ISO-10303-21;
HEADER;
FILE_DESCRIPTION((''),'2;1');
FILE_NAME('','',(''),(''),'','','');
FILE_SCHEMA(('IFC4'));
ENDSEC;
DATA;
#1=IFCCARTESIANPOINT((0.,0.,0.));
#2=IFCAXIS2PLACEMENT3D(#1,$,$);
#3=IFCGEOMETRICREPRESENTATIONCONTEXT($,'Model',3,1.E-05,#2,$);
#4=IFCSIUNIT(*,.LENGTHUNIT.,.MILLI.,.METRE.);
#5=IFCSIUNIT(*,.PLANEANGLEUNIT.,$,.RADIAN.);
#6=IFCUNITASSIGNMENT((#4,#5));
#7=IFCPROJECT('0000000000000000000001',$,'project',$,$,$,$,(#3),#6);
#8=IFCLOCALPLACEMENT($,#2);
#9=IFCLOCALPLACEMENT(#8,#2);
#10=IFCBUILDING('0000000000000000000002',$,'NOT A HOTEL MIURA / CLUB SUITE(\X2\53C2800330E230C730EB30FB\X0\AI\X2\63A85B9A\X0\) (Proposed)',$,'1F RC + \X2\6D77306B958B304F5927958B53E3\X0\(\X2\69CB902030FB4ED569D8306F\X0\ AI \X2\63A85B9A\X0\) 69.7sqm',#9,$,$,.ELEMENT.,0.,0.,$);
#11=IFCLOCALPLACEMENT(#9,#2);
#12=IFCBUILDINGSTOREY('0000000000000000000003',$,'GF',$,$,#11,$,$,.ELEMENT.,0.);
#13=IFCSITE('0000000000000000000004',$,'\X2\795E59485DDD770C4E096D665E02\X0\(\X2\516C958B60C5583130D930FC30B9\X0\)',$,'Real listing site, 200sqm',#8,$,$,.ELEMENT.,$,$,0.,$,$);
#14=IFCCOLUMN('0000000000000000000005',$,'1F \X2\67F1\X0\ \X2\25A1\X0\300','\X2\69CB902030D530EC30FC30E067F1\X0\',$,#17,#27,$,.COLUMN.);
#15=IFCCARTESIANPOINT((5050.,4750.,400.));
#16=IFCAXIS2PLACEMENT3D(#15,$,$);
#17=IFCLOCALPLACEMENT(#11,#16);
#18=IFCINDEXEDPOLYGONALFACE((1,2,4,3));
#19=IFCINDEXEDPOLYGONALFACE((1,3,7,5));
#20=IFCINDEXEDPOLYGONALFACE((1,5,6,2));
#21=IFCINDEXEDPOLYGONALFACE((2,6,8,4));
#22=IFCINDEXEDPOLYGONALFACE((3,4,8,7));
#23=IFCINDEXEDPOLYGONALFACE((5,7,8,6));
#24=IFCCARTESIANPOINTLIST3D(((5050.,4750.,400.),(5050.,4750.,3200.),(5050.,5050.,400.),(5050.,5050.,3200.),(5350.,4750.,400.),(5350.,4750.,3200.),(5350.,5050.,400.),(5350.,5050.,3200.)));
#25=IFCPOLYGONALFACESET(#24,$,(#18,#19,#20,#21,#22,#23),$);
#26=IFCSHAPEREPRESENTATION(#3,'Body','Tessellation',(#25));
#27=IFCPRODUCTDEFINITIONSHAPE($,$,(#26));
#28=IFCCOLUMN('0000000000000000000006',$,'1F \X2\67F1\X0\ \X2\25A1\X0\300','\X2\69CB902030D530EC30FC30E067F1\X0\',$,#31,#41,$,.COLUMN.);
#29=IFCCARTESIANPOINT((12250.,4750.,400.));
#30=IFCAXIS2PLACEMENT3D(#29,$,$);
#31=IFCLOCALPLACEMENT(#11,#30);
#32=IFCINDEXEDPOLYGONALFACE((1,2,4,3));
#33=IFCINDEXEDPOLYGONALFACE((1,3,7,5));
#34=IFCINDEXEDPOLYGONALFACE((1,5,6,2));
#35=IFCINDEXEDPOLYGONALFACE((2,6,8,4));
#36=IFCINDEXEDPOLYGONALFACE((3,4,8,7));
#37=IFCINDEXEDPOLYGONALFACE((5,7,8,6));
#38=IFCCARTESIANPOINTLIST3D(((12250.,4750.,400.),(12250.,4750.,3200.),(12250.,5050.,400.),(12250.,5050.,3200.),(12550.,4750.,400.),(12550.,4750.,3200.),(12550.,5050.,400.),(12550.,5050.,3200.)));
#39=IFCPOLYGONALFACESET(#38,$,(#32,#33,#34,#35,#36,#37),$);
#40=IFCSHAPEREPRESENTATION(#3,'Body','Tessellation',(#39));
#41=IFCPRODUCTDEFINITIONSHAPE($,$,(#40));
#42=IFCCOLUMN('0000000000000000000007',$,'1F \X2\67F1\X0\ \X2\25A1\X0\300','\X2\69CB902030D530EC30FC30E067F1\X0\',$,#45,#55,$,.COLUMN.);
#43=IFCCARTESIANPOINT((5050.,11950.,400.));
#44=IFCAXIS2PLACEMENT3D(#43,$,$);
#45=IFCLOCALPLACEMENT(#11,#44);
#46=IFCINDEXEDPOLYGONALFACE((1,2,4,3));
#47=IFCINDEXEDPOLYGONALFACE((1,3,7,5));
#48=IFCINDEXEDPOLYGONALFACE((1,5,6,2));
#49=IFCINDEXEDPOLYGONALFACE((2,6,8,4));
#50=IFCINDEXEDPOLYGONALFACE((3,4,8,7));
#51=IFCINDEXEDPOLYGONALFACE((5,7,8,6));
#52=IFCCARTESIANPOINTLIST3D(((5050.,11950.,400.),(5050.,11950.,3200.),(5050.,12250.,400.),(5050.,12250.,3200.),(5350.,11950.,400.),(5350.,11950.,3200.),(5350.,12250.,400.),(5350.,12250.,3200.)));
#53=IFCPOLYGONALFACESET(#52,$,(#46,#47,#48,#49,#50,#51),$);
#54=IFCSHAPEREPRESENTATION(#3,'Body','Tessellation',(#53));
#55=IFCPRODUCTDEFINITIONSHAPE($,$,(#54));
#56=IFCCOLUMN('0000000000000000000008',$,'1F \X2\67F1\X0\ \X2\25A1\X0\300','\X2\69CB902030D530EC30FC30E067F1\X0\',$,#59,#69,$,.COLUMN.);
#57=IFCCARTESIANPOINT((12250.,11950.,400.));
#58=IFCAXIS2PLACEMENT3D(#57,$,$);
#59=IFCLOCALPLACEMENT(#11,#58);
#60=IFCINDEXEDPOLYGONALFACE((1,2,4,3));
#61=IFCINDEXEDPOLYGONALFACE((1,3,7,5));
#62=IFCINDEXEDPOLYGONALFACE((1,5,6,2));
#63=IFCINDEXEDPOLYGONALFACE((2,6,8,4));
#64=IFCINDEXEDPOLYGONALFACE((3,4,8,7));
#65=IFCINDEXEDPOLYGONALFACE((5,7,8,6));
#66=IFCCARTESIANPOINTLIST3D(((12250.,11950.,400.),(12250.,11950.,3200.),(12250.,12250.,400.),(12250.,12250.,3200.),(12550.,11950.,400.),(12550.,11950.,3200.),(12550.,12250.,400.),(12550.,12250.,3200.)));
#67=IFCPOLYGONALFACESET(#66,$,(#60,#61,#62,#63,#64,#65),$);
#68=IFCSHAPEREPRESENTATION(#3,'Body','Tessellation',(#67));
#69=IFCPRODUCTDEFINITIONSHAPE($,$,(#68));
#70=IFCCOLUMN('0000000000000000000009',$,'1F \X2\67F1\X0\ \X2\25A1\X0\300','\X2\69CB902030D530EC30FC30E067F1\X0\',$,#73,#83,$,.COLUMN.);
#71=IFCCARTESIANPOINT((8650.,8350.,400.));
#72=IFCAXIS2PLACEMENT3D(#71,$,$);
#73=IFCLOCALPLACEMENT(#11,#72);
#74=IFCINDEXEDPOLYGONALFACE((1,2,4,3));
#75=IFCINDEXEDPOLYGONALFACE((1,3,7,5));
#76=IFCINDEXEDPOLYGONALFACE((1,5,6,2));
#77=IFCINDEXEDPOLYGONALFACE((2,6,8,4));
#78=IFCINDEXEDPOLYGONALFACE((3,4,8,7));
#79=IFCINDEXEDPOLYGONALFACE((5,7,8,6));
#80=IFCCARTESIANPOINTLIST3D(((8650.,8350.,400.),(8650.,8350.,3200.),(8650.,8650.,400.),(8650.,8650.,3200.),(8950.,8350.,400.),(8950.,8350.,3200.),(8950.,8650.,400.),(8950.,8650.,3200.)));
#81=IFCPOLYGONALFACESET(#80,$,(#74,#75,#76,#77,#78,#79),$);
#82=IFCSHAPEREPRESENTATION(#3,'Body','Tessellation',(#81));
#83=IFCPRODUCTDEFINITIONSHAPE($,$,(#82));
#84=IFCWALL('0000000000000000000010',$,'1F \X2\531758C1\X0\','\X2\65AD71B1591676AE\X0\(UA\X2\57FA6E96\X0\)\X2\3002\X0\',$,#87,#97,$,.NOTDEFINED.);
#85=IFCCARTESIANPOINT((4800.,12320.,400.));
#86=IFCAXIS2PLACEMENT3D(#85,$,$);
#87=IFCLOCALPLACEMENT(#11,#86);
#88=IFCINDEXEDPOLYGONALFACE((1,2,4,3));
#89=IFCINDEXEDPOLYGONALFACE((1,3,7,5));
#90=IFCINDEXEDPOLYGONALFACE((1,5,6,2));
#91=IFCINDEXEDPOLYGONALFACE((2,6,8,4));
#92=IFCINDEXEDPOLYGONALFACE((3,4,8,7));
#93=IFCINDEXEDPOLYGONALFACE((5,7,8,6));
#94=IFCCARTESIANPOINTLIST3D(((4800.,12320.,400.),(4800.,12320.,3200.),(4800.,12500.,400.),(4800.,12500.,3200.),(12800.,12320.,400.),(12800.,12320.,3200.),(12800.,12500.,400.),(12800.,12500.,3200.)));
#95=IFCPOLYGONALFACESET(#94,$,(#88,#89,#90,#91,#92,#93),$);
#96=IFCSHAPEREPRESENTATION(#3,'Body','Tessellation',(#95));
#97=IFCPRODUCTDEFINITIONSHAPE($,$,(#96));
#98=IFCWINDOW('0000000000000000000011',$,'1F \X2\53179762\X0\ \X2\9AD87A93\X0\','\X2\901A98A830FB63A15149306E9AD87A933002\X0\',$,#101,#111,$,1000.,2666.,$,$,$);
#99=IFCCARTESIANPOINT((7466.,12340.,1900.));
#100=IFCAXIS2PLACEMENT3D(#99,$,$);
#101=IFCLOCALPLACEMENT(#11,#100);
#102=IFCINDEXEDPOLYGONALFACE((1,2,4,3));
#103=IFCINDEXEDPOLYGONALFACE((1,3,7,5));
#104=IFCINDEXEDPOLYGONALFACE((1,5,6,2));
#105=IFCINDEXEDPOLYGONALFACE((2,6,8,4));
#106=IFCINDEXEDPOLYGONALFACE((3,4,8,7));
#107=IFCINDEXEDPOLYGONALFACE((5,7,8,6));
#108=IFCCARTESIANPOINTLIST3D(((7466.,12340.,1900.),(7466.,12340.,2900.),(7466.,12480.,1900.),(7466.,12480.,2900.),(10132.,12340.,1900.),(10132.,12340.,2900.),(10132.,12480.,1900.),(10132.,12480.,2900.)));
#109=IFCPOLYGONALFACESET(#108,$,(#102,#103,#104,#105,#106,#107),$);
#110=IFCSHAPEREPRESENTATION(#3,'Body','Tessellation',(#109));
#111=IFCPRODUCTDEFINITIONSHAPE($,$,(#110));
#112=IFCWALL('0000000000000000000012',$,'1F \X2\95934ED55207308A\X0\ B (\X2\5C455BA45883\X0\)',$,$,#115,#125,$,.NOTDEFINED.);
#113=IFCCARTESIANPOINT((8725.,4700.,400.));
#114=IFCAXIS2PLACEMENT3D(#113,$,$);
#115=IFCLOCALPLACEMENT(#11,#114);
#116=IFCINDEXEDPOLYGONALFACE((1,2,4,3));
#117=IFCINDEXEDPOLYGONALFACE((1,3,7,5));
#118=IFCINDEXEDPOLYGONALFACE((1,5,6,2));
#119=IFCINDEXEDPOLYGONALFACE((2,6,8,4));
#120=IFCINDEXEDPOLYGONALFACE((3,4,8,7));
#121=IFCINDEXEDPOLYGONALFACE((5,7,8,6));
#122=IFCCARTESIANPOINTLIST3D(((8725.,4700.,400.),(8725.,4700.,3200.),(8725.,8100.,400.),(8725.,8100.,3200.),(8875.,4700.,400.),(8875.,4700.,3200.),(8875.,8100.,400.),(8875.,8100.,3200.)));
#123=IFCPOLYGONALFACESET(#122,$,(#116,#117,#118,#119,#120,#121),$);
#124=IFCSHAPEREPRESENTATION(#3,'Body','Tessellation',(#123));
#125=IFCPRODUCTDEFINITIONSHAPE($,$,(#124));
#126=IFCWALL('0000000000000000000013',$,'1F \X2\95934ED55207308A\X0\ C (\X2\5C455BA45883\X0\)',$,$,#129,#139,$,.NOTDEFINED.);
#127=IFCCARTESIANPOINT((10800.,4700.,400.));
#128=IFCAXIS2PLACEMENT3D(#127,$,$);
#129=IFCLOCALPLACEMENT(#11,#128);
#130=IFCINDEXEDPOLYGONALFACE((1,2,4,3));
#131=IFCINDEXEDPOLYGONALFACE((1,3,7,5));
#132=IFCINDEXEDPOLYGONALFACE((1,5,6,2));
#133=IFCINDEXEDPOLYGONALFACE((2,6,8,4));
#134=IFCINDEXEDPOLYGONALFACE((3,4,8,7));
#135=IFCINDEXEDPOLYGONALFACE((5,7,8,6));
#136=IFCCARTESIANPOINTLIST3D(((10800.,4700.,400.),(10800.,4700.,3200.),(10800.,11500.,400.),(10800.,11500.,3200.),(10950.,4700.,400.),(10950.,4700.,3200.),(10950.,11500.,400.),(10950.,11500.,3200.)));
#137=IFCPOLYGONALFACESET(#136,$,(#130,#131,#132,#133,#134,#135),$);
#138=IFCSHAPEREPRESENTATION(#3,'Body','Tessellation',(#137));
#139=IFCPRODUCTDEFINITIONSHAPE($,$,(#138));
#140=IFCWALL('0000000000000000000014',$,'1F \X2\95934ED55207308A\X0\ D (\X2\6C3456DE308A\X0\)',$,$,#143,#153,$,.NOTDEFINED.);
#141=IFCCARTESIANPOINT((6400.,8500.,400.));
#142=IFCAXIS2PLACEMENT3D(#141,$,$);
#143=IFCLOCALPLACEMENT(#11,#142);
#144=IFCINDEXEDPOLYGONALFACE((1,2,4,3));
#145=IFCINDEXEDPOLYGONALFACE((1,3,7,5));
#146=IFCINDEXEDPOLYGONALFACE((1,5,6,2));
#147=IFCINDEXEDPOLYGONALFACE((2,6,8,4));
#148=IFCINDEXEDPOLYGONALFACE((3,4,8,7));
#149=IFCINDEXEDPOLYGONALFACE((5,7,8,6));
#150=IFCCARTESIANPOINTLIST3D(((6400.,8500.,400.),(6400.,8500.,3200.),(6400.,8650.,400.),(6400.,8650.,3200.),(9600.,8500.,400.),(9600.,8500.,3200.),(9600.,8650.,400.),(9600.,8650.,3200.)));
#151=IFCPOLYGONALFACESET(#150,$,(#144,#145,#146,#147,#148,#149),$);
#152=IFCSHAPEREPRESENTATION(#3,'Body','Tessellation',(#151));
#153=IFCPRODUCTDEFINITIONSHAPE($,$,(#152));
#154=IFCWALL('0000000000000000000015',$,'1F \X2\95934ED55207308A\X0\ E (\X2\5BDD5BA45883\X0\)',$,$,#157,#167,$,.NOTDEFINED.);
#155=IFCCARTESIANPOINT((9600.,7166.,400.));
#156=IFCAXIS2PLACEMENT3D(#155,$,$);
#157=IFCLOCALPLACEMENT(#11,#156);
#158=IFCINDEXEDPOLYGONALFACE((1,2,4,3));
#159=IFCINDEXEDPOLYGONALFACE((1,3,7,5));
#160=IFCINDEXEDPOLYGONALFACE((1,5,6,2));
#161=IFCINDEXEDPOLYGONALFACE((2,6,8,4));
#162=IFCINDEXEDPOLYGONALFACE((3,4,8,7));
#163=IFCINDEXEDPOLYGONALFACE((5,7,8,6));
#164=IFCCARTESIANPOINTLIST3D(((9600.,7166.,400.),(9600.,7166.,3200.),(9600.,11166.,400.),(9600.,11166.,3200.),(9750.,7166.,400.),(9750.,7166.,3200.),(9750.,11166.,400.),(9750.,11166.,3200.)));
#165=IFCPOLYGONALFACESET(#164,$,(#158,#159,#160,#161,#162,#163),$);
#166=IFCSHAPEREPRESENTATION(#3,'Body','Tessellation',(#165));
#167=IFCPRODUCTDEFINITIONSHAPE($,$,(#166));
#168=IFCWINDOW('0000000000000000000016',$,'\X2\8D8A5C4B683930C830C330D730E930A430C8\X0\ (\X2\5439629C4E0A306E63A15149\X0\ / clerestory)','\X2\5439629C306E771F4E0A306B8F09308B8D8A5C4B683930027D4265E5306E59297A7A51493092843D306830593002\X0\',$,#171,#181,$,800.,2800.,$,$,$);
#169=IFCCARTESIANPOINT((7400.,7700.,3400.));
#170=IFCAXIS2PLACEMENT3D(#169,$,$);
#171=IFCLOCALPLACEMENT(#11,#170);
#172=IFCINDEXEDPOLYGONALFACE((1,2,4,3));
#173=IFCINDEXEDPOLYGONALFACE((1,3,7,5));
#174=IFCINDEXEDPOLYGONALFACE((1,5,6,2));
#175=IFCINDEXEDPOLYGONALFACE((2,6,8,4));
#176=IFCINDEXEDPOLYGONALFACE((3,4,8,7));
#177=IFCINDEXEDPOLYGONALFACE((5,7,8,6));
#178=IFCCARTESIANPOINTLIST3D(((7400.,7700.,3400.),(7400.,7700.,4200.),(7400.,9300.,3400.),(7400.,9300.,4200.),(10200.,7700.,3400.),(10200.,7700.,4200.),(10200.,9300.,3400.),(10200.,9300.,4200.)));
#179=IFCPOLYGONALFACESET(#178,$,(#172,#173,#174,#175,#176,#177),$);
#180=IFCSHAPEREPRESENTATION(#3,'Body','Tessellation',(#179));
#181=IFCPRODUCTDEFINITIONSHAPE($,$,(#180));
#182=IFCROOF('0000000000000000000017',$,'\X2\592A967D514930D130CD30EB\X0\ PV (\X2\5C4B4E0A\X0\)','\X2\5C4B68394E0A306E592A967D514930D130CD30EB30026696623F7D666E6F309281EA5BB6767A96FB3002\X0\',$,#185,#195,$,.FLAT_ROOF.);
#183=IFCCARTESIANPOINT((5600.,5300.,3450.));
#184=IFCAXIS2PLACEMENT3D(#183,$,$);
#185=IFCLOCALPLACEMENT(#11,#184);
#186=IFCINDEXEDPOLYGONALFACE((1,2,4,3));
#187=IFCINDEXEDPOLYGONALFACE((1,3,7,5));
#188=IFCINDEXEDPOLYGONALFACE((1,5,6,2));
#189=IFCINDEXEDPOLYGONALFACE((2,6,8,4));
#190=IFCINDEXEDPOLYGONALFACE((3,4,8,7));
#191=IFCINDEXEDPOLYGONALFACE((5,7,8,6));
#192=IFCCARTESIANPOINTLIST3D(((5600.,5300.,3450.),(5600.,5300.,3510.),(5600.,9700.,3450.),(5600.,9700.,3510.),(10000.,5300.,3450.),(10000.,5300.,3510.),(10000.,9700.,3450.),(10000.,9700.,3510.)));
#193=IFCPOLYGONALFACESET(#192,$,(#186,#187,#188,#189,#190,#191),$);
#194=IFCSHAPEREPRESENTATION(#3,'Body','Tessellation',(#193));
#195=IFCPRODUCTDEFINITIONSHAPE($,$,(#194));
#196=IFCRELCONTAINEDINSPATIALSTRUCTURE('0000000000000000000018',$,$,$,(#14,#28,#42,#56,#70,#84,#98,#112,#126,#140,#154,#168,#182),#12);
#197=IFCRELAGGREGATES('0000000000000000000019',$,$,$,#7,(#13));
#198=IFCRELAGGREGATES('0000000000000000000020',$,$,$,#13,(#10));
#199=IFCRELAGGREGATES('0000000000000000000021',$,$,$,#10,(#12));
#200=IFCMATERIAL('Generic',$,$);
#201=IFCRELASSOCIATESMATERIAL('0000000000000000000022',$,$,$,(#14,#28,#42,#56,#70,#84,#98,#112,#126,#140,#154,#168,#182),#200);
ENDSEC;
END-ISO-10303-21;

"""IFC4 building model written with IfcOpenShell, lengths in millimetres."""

from ifc_helpers import new_model, si_unit, frame, frame_2d, origin, place, context, project, spatial, rectangle, extrude, material, element, fill, save


model = new_model("IFC4")

# Units and contexts
model_context = context("Model", 3, precision=1e-05, world=origin())
ifc_project = project(units=[si_unit("LENGTHUNIT", "METRE", prefix="MILLI"), si_unit("PLANEANGLEUNIT", "RADIAN")], contexts=[model_context])

# Site, building, storey
site_placement = place(None, origin())
site = spatial("IfcSite", under=ifc_project, at=site_placement, Name="神奈川県三浦市(公開情報ベース)", ObjectType="Real listing site, 200sqm", CompositionType="ELEMENT", RefElevation=0.0)
building_placement = place(site_placement, origin())
building = spatial("IfcBuilding", under=site, at=building_placement, Name="NOT A HOTEL MIURA / CLUB SUITE(参考モデル・AI推定) (Proposed)", ObjectType="1F RC + 海に開く大開口(構造・仕様は AI 推定) 69.7sqm", CompositionType="ELEMENT", ElevationOfRefHeight=0.0, ElevationOfTerrain=0.0)
storey_placement = place(building_placement, origin())
storey = spatial("IfcBuildingStorey", under=building, at=storey_placement, Name="GF", CompositionType="ELEMENT", Elevation=0.0)

# Columns
ifc_material_1 = material(Name="Generic")
column_1_placement = place(storey_placement, frame((5050.0, 4750.0, 400.0)))
element("IfcColumn", 1, at=column_1_placement, inside=storey, material=ifc_material_1, Name="1F 柱 □300", Description="構造フレーム柱", PredefinedType="COLUMN", context=model_context, shape_type="SweptSolid", body=[
    extrude(rectangle(XDim=300.0, YDim=300.0, at=frame_2d((150.0, 150.0))), frame((5050.0, 4750.0, 400.0)), (0.0, 0.0, 1.0), 2800.0),
])
column_2_placement = place(storey_placement, frame((12250.0, 4750.0, 400.0)))
element("IfcColumn", 2, at=column_2_placement, inside=storey, material=ifc_material_1, Name="1F 柱 □300", Description="構造フレーム柱", PredefinedType="COLUMN", context=model_context, shape_type="SweptSolid", body=[
    extrude(rectangle(XDim=300.0, YDim=300.0, at=frame_2d((150.0, 150.0))), frame((12250.0, 4750.0, 400.0)), (0.0, 0.0, 1.0), 2800.0),
])
column_3_placement = place(storey_placement, frame((5050.0, 11950.0, 400.0)))
element("IfcColumn", 3, at=column_3_placement, inside=storey, material=ifc_material_1, Name="1F 柱 □300", Description="構造フレーム柱", PredefinedType="COLUMN", context=model_context, shape_type="SweptSolid", body=[
    extrude(rectangle(XDim=300.0, YDim=300.0, at=frame_2d((150.0, 150.0))), frame((5050.0, 11950.0, 400.0)), (0.0, 0.0, 1.0), 2800.0),
])
column_4_placement = place(storey_placement, frame((12250.0, 11950.0, 400.0)))
element("IfcColumn", 4, at=column_4_placement, inside=storey, material=ifc_material_1, Name="1F 柱 □300", Description="構造フレーム柱", PredefinedType="COLUMN", context=model_context, shape_type="SweptSolid", body=[
    extrude(rectangle(XDim=300.0, YDim=300.0, at=frame_2d((150.0, 150.0))), frame((12250.0, 11950.0, 400.0)), (0.0, 0.0, 1.0), 2800.0),
])
column_5_placement = place(storey_placement, frame((8650.0, 8350.0, 400.0)))
element("IfcColumn", 5, at=column_5_placement, inside=storey, material=ifc_material_1, Name="1F 柱 □300", Description="構造フレーム柱", PredefinedType="COLUMN", context=model_context, shape_type="SweptSolid", body=[
    extrude(rectangle(XDim=300.0, YDim=300.0, at=frame_2d((150.0, 150.0))), frame((8650.0, 8350.0, 400.0)), (0.0, 0.0, 1.0), 2800.0),
])

# Wall, opening, window
wall_1_placement = place(storey_placement, frame((4800.0, 12320.0, 400.0)))
wall_1 = element("IfcWall", 6, at=wall_1_placement, inside=storey, material=ifc_material_1, Name="1F 北壁", Description="断熱外皮(UA基準)。", PredefinedType="NOTDEFINED", context=model_context, shape_type="SweptSolid", body=[
    extrude(rectangle(XDim=8000.0, YDim=180.0, at=frame_2d((4000.0, 90.0))), frame((4800.0, 12320.0, 400.0)), (0.0, 0.0, 1.0), 2800.0),
])
opening_placement = place(storey_placement, frame((7466.0, 12340.0, 1900.0)))
opening = element("IfcOpeningElement", 7, at=opening_placement, cuts=wall_1, PredefinedType="NOTDEFINED", context=model_context, shape_type="SweptSolid", body=[
    extrude(rectangle(XDim=2666.0, YDim=140.0, at=frame_2d((1333.0, 70.0))), frame((7466.0, 12340.0, 1900.0)), (0.0, 0.0, 1.0), 1000.0),
])
window_1_placement = place(storey_placement, frame((7466.0, 12340.0, 1900.0)))
window_1 = element("IfcWindow", 8, at=window_1_placement, inside=storey, material=ifc_material_1, Name="1F 北面 高窓", Description="通風・採光の高窓。", OverallHeight=1000.0, OverallWidth=2666.0, context=model_context, shape_type="SweptSolid", body=[
    extrude(rectangle(XDim=2666.0, YDim=140.0, at=frame_2d((1333.0, 70.0))), frame((7466.0, 12340.0, 1900.0)), (0.0, 0.0, 1.0), 1000.0),
])
fill(opening, window_1)

# Walls
wall_2_placement = place(storey_placement, frame((8725.0, 4700.0, 400.0)))
element("IfcWall", 9, at=wall_2_placement, inside=storey, material=ifc_material_1, Name="1F 間仕切り B (居室境)", PredefinedType="NOTDEFINED", context=model_context, shape_type="SweptSolid", body=[
    extrude(rectangle(XDim=150.0, YDim=3400.0, at=frame_2d((75.0, 1700.0))), frame((8725.0, 4700.0, 400.0)), (0.0, 0.0, 1.0), 2800.0),
])
wall_3_placement = place(storey_placement, frame((10800.0, 4700.0, 400.0)))
element("IfcWall", 10, at=wall_3_placement, inside=storey, material=ifc_material_1, Name="1F 間仕切り C (居室境)", PredefinedType="NOTDEFINED", context=model_context, shape_type="SweptSolid", body=[
    extrude(rectangle(XDim=150.0, YDim=6800.0, at=frame_2d((75.0, 3400.0))), frame((10800.0, 4700.0, 400.0)), (0.0, 0.0, 1.0), 2800.0),
])
wall_4_placement = place(storey_placement, frame((6400.0, 8500.0, 400.0)))
element("IfcWall", 11, at=wall_4_placement, inside=storey, material=ifc_material_1, Name="1F 間仕切り D (水回り)", PredefinedType="NOTDEFINED", context=model_context, shape_type="SweptSolid", body=[
    extrude(rectangle(XDim=3200.0, YDim=150.0, at=frame_2d((1600.0, 75.0))), frame((6400.0, 8500.0, 400.0)), (0.0, 0.0, 1.0), 2800.0),
])
wall_5_placement = place(storey_placement, frame((9600.0, 7166.0, 400.0)))
element("IfcWall", 12, at=wall_5_placement, inside=storey, material=ifc_material_1, Name="1F 間仕切り E (寝室境)", PredefinedType="NOTDEFINED", context=model_context, shape_type="SweptSolid", body=[
    extrude(rectangle(XDim=150.0, YDim=4000.0, at=frame_2d((75.0, 2000.0))), frame((9600.0, 7166.0, 400.0)), (0.0, 0.0, 1.0), 2800.0),
])

# Window
window_2_placement = place(storey_placement, frame((7400.0, 7700.0, 3400.0)))
element("IfcWindow", 13, at=window_2_placement, inside=storey, material=ifc_material_1, Name="越屋根トップライト (吹抜上の採光 / clerestory)", Description="吹抜の真上に載る越屋根。終日の天空光を落とす。", OverallHeight=800.0, OverallWidth=2800.0, context=model_context, shape_type="SweptSolid", body=[
    extrude(rectangle(XDim=2800.0, YDim=1600.0, at=frame_2d((1400.0, 800.0))), frame((7400.0, 7700.0, 3400.0)), (0.0, 0.0, 1.0), 800.0),
])

# Roof
roof_placement = place(storey_placement, frame((5600.0, 5300.0, 3450.0)))
element("IfcRoof", 14, at=roof_placement, inside=storey, material=ifc_material_1, Name="太陽光パネル PV (屋上)", Description="屋根上の太陽光パネル。暖房給湯を自家発電。", PredefinedType="FLAT_ROOF", context=model_context, shape_type="SweptSolid", body=[
    extrude(rectangle(XDim=4400.0, YDim=4400.0, at=frame_2d((2200.0, 2200.0))), frame((5600.0, 5300.0, 3450.0)), (0.0, 0.0, 1.0), 60.0),
])

save(model, "model.ifc")
